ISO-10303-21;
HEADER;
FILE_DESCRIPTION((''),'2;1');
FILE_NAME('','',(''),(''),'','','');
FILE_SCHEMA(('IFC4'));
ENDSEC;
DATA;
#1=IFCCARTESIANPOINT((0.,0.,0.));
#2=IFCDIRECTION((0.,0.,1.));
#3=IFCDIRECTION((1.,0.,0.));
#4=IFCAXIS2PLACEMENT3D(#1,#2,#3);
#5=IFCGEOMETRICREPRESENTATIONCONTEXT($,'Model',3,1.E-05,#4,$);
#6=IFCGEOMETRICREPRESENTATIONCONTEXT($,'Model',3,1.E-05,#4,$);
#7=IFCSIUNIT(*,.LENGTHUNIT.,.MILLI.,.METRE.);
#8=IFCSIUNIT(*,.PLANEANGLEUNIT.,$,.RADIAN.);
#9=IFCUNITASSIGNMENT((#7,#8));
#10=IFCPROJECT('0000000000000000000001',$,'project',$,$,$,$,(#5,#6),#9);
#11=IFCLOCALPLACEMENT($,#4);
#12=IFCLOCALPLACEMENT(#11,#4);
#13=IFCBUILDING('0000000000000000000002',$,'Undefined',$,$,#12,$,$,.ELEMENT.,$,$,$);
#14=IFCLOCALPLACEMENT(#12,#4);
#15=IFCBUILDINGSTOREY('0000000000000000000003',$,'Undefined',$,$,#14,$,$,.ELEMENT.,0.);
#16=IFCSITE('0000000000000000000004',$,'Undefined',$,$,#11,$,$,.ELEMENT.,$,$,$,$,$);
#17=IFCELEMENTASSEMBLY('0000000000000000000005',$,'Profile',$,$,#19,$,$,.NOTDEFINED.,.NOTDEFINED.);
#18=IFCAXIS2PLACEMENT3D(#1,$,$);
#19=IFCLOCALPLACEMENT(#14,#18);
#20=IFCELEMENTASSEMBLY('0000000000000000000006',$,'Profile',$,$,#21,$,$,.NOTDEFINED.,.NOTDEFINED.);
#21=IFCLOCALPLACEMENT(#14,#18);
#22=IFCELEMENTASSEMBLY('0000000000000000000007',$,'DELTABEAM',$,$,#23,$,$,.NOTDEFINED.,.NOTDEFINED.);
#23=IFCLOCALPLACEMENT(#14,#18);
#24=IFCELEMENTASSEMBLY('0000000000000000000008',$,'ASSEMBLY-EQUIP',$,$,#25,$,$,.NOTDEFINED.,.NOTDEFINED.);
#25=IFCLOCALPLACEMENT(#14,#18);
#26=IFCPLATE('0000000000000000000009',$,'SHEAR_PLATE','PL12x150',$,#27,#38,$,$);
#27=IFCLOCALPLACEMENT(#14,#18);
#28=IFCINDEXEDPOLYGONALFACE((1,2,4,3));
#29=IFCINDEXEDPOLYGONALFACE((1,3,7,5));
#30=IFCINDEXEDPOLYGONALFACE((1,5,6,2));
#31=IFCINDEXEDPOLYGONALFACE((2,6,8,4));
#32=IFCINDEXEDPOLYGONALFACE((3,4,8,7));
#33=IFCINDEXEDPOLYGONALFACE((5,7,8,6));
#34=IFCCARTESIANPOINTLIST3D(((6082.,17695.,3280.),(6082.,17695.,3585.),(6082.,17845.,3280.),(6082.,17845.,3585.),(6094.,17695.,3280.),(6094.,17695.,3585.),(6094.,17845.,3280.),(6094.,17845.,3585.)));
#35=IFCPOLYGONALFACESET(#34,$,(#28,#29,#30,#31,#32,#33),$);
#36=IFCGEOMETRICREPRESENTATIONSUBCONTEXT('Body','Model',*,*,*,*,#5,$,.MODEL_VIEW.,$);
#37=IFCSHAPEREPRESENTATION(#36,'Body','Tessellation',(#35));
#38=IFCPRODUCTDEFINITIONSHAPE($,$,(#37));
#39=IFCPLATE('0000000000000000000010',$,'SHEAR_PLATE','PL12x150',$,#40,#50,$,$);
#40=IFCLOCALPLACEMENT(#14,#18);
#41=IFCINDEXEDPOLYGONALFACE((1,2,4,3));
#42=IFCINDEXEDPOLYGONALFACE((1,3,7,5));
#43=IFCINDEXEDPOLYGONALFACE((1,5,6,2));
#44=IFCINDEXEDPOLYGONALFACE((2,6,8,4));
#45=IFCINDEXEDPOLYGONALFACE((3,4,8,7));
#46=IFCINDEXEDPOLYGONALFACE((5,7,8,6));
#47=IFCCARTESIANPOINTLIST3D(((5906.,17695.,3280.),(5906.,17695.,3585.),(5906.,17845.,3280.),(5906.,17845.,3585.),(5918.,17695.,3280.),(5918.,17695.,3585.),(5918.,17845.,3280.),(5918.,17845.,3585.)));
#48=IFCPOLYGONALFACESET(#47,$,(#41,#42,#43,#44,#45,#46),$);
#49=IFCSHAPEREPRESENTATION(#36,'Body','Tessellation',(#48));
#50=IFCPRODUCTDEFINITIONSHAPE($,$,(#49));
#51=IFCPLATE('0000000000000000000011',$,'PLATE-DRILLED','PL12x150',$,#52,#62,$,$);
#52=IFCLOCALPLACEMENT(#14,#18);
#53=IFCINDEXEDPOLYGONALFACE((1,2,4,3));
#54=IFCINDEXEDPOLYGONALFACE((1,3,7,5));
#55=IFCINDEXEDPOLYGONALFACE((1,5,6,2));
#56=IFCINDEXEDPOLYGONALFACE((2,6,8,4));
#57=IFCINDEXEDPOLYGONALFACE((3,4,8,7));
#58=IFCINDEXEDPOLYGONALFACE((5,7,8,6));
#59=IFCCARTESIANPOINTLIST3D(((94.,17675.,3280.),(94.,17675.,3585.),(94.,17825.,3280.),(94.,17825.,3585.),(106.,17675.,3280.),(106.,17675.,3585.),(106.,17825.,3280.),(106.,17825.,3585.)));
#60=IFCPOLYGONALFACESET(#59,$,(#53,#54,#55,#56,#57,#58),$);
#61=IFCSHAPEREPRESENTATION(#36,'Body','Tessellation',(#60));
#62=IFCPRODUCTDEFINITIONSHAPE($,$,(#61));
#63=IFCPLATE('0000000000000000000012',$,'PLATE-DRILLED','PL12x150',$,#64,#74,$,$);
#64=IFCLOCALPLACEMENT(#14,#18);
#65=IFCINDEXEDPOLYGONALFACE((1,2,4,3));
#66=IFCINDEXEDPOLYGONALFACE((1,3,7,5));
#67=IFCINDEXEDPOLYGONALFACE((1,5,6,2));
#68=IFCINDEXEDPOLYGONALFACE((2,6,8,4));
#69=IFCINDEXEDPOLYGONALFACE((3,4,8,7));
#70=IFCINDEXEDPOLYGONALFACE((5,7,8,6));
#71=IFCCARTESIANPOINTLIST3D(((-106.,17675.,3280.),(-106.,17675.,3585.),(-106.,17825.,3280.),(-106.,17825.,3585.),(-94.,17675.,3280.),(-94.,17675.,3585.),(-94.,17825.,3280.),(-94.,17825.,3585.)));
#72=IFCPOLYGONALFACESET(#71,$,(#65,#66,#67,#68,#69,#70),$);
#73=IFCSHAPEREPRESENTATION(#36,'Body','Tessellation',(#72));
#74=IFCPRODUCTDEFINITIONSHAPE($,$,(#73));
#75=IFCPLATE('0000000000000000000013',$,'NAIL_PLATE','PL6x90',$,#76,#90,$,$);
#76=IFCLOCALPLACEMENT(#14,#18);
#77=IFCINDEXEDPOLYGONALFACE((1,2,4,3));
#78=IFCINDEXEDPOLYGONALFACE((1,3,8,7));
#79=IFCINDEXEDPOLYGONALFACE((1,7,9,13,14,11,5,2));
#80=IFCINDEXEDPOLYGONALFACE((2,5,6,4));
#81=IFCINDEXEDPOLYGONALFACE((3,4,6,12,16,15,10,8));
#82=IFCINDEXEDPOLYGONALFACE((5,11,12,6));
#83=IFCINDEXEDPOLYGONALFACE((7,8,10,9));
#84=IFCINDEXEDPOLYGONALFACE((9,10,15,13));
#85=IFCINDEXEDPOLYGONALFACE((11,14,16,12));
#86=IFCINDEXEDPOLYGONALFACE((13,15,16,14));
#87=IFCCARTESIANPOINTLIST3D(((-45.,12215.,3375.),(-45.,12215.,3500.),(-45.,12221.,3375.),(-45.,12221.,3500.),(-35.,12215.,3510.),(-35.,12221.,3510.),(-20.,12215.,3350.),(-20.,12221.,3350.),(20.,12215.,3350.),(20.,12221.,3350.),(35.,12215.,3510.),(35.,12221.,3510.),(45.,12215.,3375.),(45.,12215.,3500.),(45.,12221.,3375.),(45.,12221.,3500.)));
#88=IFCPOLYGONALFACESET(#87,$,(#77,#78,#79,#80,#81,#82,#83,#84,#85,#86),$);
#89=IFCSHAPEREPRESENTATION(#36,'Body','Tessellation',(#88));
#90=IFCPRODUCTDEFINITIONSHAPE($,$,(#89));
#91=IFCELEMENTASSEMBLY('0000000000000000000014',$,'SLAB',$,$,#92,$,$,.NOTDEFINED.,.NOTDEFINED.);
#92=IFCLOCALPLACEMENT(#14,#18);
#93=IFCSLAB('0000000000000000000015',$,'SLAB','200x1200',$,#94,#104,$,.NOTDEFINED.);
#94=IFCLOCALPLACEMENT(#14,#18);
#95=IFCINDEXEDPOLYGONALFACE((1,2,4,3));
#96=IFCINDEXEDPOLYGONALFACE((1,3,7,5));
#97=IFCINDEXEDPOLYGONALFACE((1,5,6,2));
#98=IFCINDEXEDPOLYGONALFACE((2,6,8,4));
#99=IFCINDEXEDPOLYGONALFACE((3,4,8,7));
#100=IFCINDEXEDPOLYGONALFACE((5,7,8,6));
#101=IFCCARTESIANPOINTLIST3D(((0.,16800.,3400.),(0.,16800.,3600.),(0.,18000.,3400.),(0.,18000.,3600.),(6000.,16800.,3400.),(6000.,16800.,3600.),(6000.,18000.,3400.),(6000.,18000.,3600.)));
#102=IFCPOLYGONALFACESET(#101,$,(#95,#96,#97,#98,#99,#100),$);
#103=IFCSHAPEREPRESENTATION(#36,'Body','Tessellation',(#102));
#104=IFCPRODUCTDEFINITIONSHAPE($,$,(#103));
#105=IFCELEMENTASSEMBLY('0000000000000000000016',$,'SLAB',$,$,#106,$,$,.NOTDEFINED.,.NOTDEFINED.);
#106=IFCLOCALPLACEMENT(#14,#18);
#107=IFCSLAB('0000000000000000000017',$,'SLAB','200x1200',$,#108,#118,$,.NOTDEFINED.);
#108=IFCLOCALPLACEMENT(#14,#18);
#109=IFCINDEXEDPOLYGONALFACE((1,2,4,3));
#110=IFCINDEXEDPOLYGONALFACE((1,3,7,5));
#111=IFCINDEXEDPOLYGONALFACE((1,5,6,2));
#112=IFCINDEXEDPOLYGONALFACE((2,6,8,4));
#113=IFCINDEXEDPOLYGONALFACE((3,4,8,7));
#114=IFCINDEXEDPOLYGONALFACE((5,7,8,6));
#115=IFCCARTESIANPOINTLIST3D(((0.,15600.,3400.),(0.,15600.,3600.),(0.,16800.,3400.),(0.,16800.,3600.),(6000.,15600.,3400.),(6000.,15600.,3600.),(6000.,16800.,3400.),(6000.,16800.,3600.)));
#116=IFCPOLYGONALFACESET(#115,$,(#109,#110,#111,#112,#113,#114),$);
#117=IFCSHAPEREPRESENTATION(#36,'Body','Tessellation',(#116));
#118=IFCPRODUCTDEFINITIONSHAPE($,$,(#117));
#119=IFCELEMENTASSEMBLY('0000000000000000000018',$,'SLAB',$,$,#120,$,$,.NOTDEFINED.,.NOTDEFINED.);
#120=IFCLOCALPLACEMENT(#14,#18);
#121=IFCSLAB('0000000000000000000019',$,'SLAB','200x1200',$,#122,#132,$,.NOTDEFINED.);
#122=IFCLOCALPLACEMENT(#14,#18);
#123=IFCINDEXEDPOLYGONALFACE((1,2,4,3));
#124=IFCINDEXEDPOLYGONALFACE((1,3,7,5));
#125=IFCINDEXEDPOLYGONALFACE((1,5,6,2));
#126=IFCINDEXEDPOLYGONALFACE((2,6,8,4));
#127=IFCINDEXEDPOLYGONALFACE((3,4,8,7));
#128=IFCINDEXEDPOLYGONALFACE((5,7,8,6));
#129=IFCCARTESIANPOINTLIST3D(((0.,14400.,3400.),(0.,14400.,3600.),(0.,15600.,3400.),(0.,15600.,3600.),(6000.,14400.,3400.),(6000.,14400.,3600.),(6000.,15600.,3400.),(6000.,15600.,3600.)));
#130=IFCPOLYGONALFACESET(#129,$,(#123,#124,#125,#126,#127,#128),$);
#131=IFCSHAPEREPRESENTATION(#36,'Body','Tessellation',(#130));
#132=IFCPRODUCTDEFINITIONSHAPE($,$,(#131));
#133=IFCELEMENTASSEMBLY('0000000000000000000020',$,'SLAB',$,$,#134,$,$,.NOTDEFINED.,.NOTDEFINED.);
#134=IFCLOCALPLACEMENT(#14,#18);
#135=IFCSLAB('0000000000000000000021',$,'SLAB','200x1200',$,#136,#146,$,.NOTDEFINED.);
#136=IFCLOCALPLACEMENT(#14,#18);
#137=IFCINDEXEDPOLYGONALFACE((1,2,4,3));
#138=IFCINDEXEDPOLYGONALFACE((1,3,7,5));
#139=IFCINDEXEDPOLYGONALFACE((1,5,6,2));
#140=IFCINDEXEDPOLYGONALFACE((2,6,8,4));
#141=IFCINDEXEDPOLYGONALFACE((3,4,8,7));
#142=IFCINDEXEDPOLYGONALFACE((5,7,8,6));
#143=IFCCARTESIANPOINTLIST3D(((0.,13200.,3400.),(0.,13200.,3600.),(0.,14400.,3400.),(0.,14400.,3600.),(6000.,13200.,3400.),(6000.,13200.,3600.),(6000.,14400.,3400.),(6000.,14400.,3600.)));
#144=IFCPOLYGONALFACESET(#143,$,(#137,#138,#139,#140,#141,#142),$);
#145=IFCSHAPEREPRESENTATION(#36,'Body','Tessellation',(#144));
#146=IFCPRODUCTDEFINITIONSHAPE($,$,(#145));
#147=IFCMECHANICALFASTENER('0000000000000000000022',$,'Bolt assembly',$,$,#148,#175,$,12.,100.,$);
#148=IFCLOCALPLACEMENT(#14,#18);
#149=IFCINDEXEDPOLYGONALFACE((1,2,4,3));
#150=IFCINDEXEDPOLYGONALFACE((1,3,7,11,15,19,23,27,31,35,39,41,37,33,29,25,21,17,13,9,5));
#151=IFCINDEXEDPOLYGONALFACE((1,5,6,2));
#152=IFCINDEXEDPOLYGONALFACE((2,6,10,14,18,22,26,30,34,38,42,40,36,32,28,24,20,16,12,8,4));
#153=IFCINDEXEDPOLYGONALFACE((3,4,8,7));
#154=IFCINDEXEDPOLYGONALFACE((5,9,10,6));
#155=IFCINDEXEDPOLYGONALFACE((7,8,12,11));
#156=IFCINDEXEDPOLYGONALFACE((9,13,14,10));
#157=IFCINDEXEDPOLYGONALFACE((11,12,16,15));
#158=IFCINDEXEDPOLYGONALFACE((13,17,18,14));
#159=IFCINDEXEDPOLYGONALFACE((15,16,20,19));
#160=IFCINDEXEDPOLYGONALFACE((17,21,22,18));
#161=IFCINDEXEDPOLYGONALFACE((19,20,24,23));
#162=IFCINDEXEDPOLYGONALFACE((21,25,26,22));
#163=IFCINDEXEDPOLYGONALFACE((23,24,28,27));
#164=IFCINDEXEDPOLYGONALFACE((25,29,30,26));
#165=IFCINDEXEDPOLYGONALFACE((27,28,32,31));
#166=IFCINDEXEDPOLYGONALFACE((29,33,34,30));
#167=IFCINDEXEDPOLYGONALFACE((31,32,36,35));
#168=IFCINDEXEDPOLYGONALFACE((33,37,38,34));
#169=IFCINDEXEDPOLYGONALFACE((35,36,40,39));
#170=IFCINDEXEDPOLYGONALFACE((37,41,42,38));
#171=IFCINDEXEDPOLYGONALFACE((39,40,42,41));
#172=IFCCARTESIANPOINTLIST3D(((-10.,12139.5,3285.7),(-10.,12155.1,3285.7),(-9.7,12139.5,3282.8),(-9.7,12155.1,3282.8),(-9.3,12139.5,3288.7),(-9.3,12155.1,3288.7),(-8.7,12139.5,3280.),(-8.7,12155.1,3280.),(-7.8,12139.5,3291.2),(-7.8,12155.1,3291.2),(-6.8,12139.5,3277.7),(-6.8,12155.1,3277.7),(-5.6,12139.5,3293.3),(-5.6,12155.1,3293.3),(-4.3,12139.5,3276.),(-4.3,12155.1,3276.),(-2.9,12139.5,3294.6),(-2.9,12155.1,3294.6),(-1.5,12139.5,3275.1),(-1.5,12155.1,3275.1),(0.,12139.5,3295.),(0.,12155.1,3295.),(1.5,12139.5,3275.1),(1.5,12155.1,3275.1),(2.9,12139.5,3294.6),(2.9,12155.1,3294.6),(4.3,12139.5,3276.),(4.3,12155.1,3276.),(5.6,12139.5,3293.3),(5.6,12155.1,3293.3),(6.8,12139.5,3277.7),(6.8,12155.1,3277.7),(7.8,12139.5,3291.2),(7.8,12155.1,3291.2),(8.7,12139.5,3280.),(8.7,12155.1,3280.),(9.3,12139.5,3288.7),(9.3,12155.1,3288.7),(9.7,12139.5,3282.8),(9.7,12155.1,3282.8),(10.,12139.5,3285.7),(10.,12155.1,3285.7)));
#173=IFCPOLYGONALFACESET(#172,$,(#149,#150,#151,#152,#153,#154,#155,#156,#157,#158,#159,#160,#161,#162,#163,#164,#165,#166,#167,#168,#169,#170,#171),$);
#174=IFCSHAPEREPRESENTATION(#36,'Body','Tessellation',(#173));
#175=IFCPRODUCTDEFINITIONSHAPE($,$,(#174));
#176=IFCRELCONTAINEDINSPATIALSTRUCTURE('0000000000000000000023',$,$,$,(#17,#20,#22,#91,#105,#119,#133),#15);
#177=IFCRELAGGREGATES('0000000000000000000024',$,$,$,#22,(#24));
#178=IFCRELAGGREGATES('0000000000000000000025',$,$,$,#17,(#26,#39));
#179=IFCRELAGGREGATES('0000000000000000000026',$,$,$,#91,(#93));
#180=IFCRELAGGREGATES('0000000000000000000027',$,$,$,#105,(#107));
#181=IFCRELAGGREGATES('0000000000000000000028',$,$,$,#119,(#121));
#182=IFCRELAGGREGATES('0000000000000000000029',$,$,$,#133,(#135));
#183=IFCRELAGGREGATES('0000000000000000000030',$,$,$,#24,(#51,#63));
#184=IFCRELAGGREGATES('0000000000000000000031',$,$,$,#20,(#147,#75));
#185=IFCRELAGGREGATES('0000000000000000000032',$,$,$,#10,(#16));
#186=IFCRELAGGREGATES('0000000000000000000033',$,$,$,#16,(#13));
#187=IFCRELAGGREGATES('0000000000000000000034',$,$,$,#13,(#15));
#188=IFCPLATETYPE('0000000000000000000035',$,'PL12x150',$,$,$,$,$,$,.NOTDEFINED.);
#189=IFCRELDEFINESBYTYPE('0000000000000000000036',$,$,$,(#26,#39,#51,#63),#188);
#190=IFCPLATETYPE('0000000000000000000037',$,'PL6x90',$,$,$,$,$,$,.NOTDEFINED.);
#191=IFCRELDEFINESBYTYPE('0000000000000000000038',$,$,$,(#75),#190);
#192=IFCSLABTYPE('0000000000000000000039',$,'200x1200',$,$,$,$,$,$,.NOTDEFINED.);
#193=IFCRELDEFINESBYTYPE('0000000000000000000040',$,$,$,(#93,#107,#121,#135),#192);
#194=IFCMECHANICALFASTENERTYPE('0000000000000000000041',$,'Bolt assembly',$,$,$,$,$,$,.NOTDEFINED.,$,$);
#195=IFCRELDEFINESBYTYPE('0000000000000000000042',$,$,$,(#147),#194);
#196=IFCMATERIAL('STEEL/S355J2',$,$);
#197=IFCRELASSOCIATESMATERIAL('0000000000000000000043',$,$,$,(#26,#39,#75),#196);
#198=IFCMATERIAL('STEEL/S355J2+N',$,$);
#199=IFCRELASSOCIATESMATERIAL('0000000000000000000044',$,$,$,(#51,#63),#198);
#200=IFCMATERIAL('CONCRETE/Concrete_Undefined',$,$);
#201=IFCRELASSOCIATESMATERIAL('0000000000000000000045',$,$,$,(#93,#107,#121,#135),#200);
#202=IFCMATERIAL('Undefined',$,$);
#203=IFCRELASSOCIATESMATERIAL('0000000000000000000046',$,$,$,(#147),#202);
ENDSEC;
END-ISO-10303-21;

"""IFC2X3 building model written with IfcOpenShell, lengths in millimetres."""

from ifc_helpers import new_model, si_unit, frame, origin_with_axes, origin_2d_with_axis, place, context, subcontext, project, spatial, polyline, circle, outline, extrude, source, transform, mapped, material, type_object, element, aggregate, save


model = new_model("IFC2X3")

# Units and contexts
model_context_1 = context("Model", 3, precision=1e-05, world=origin_with_axes())
model_context_2 = context("Model", 3, precision=1e-05, world=origin_with_axes())
body_context = subcontext(model_context_1, "Body", "Model", "MODEL_VIEW")
ifc_project = project(units=[si_unit("LENGTHUNIT", "METRE", prefix="MILLI"), si_unit("PLANEANGLEUNIT", "RADIAN")], contexts=[model_context_1, model_context_2])

# Site, building, storey
site_placement = place(None, origin_with_axes())
site = spatial("IfcSite", under=ifc_project, at=site_placement, Name="Undefined", CompositionType="ELEMENT")
building_placement = place(site_placement, origin_with_axes())
building = spatial("IfcBuilding", under=site, at=building_placement, Name="Undefined", CompositionType="ELEMENT")
storey_placement = place(building_placement, origin_with_axes())
storey = spatial("IfcBuildingStorey", under=building, at=storey_placement, Name="Undefined", CompositionType="ELEMENT", Elevation=0.0)

# Shared definitions
ifc_material_1 = material(Name="CONCRETE/Concrete_Undefined")

# Element assembly
assembly_1_placement = place(storey_placement, origin_with_axes())
assembly_1 = element("IfcElementAssembly", 1, at=assembly_1_placement, inside=storey, Name="Profile", AssemblyPlace="NOTDEFINED", PredefinedType="NOTDEFINED")

# Shared definitions
ifc_material_2 = material(Name="STEEL/S355J2")

# Element assembly
assembly_2_placement = place(storey_placement, origin_with_axes())
assembly_2 = element("IfcElementAssembly", 2, at=assembly_2_placement, inside=storey, Name="Profile", AssemblyPlace="NOTDEFINED", PredefinedType="NOTDEFINED")

# Element assemblies
ifc_material_3 = material(Name="STEEL/S355J2+N")
assembly_3_placement = place(storey_placement, origin_with_axes())
assembly_3 = element("IfcElementAssembly", 3, at=assembly_3_placement, inside=storey, Name="DELTABEAM", AssemblyPlace="NOTDEFINED", PredefinedType="NOTDEFINED")
assembly_4_placement = place(assembly_3_placement, origin_with_axes())
assembly_4 = element("IfcElementAssembly", 4, at=assembly_4_placement, Name="ASSEMBLY-EQUIP", AssemblyPlace="NOTDEFINED", PredefinedType="NOTDEFINED")
aggregate(assembly_3, [assembly_4])

# Plates
plate_type_1 = type_object("IfcPlateType", Name="PL12x150", PredefinedType="NOTDEFINED")
plate_1_placement = place(assembly_1_placement, frame((6088.0, 17845.0, 3585.0), z_axis=(1.0, 0.0, 0.0), x_axis=(0.0, -1.0, 0.0)))
plate_1 = element("IfcPlate", 5, at=plate_1_placement, type_object=plate_type_1, material=ifc_material_2, Name="SHEAR_PLATE", Description="PL12x150", context=body_context, shape_type="SweptSolid", body=[
    extrude(outline(polyline([(0.0, 0.0), (150.0, 0.0), (150.0, 0.0), (150.0, 305.0), (150.0, 305.0), (0.0, 305.0), (0.0, 305.0), (0.0, 0.0)])), frame((0.0, 0.0, -6.0), z_axis=(0.0, 0.0, 1.0), x_axis=(1.0, 0.0, 0.0)), (0.0, 0.0, 1.0), 12.0),
])
plate_2_placement = place(assembly_1_placement, frame((5912.0, 17845.0, 3585.0), z_axis=(1.0, 0.0, 0.0), x_axis=(0.0, -1.0, 0.0)))
plate_2 = element("IfcPlate", 6, at=plate_2_placement, type_object=plate_type_1, material=ifc_material_2, Name="SHEAR_PLATE", Description="PL12x150", context=body_context, shape_type="SweptSolid", body=[
    extrude(outline(polyline([(0.0, 0.0), (150.0, 0.0), (150.0, 0.0), (150.0, 305.0), (150.0, 305.0), (0.0, 305.0), (0.0, 305.0), (0.0, 0.0)])), frame((0.0, 0.0, -6.0), z_axis=(0.0, 0.0, 1.0), x_axis=(1.0, 0.0, 0.0)), (0.0, 0.0, 1.0), 12.0),
])
aggregate(assembly_1, [plate_1, plate_2])
plate_3_placement = place(assembly_4_placement, frame((100.0, 17675.0, 3585.0), z_axis=(-1.0, 0.0, 0.0), x_axis=(0.0, 1.0, 0.0)))
plate_3 = element("IfcPlate", 7, at=plate_3_placement, type_object=plate_type_1, material=ifc_material_3, Name="PLATE-DRILLED", Description="PL12x150", context=body_context, shape_type="SweptSolid", body=[
    extrude(outline(polyline([(0.0, 0.0), (150.0, 0.0), (150.0, 0.0), (150.0, 305.0), (150.0, 305.0), (0.0, 305.0), (0.0, 305.0), (0.0, 0.0)])), frame((0.0, 0.0, -6.0), z_axis=(0.0, 0.0, 1.0), x_axis=(1.0, 0.0, 0.0)), (0.0, 0.0, 1.0), 12.0),
])
plate_4_placement = place(assembly_4_placement, frame((-100.0, 17675.0, 3585.0), z_axis=(-1.0, 0.0, 0.0), x_axis=(0.0, 1.0, 0.0)))
plate_4 = element("IfcPlate", 8, at=plate_4_placement, type_object=plate_type_1, material=ifc_material_3, Name="PLATE-DRILLED", Description="PL12x150", context=body_context, shape_type="SweptSolid", body=[
    extrude(outline(polyline([(0.0, 0.0), (150.0, 0.0), (150.0, 0.0), (150.0, 305.0), (150.0, 305.0), (0.0, 305.0), (0.0, 305.0), (0.0, 0.0)])), frame((0.0, 0.0, -6.0), z_axis=(0.0, 0.0, 1.0), x_axis=(1.0, 0.0, 0.0)), (0.0, 0.0, 1.0), 12.0),
])
plate_type_2 = type_object("IfcPlateType", Name="PL6x90", PredefinedType="NOTDEFINED")
plate_5_placement = place(assembly_2_placement, frame((45.0, 12218.0, 3510.0), z_axis=(0.0, -1.0, 0.0), x_axis=(-1.0, 0.0, 0.0)))
plate_5 = element("IfcPlate", 9, at=plate_5_placement, type_object=plate_type_2, material=ifc_material_2, Name="NAIL_PLATE", Description="PL6x90", context=body_context, shape_type="SweptSolid", body=[
    extrude(outline(polyline([(0.0, 10.0), (10.0, 0.0), (80.0, 0.0), (90.0, 10.0), (90.0, 135.0), (65.0, 160.0), (25.0, 160.0), (0.0, 135.0), (0.0, 10.0)])), frame((0.0, 0.0, -3.0), z_axis=(0.0, 0.0, 1.0), x_axis=(1.0, 0.0, 0.0)), (0.0, 0.0, 1.0), 6.0),
])

# Element assemblies, slabs
assembly_5_placement = place(storey_placement, origin_with_axes())
assembly_5 = element("IfcElementAssembly", 10, at=assembly_5_placement, inside=storey, Name="SLAB", AssemblyPlace="NOTDEFINED", PredefinedType="NOTDEFINED")
slab_type = type_object("IfcSlabType", Name="200x1200", PredefinedType="NOTDEFINED")
slab_1_placement = place(assembly_5_placement, frame((6000.0, 16800.0, 3500.0), z_axis=(0.0, 0.0, 1.0), x_axis=(0.0, 1.0, 0.0)))
slab_1 = element("IfcSlab", 11, at=slab_1_placement, type_object=slab_type, material=ifc_material_1, Name="SLAB", Description="200x1200", PredefinedType="NOTDEFINED", context=body_context, shape_type="SweptSolid", body=[
    extrude(outline(polyline([(0.0, 0.0), (1200.0, 0.0), (1200.0, 6000.0), (0.0, 6000.0), (0.0, 0.0)])), frame((0.0, 0.0, -100.0), z_axis=(0.0, 0.0, 1.0), x_axis=(1.0, 0.0, 0.0)), (0.0, 0.0, 1.0), 200.0),
])
aggregate(assembly_5, [slab_1])
assembly_6_placement = place(storey_placement, origin_with_axes())
assembly_6 = element("IfcElementAssembly", 12, at=assembly_6_placement, inside=storey, Name="SLAB", AssemblyPlace="NOTDEFINED", PredefinedType="NOTDEFINED")
slab_2_placement = place(assembly_6_placement, frame((6000.0, 15600.0, 3500.0), z_axis=(0.0, 0.0, 1.0), x_axis=(0.0, 1.0, 0.0)))
slab_2 = element("IfcSlab", 13, at=slab_2_placement, type_object=slab_type, material=ifc_material_1, Name="SLAB", Description="200x1200", PredefinedType="NOTDEFINED", context=body_context, shape_type="SweptSolid", body=[
    extrude(outline(polyline([(0.0, 0.0), (1200.0, 0.0), (1200.0, 6000.0), (0.0, 6000.0), (0.0, 0.0)])), frame((0.0, 0.0, -100.0), z_axis=(0.0, 0.0, 1.0), x_axis=(1.0, 0.0, 0.0)), (0.0, 0.0, 1.0), 200.0),
])
aggregate(assembly_6, [slab_2])
assembly_7_placement = place(storey_placement, origin_with_axes())
assembly_7 = element("IfcElementAssembly", 14, at=assembly_7_placement, inside=storey, Name="SLAB", AssemblyPlace="NOTDEFINED", PredefinedType="NOTDEFINED")
slab_3_placement = place(assembly_7_placement, frame((6000.0, 14400.0, 3500.0), z_axis=(0.0, 0.0, 1.0), x_axis=(0.0, 1.0, 0.0)))
slab_3 = element("IfcSlab", 15, at=slab_3_placement, type_object=slab_type, material=ifc_material_1, Name="SLAB", Description="200x1200", PredefinedType="NOTDEFINED", context=body_context, shape_type="SweptSolid", body=[
    extrude(outline(polyline([(0.0, 0.0), (1200.0, 0.0), (1200.0, 6000.0), (0.0, 6000.0), (0.0, 0.0)])), frame((0.0, 0.0, -100.0), z_axis=(0.0, 0.0, 1.0), x_axis=(1.0, 0.0, 0.0)), (0.0, 0.0, 1.0), 200.0),
])
aggregate(assembly_7, [slab_3])
assembly_8_placement = place(storey_placement, origin_with_axes())
assembly_8 = element("IfcElementAssembly", 16, at=assembly_8_placement, inside=storey, Name="SLAB", AssemblyPlace="NOTDEFINED", PredefinedType="NOTDEFINED")
slab_4_placement = place(assembly_8_placement, frame((6000.0, 13200.0, 3500.0), z_axis=(0.0, 0.0, 1.0), x_axis=(0.0, 1.0, 0.0)))
slab_4 = element("IfcSlab", 17, at=slab_4_placement, type_object=slab_type, material=ifc_material_1, Name="SLAB", Description="200x1200", PredefinedType="NOTDEFINED", context=body_context, shape_type="SweptSolid", body=[
    extrude(outline(polyline([(0.0, 0.0), (1200.0, 0.0), (1200.0, 6000.0), (0.0, 6000.0), (0.0, 0.0)])), frame((0.0, 0.0, -100.0), z_axis=(0.0, 0.0, 1.0), x_axis=(1.0, 0.0, 0.0)), (0.0, 0.0, 1.0), 200.0),
])
aggregate(assembly_8, [slab_4])

# Mechanical fastener
mechanical_fastener_type = type_object("IfcMechanicalFastenerType", Name="Bolt assembly")
aggregate(assembly_4, [plate_3, plate_4])
ifc_material_4 = material(Name="Undefined")
shared_shape_1 = source(origin_with_axes(), body_context, "Body", "SweptSolid", [
    extrude(circle(Radius=10.0, at=origin_2d_with_axis()), frame((0.0, -15.5, 0.0), z_axis=(0.0, 1.0, 0.0), x_axis=(1.0, 0.0, 0.0)), (0.0, 0.0, 1.0), 15.6),
])
mechanical_fastener_1_placement = place(assembly_2_placement, frame((0.0, 12155.0, 3285.0), z_axis=(-1.0, 0.0, 0.0), x_axis=(0.0, 0.0, 1.0)))
mechanical_fastener_1 = element("IfcMechanicalFastener", 18, at=mechanical_fastener_1_placement, type_object=mechanical_fastener_type, material=ifc_material_4, Name="Bolt assembly", NominalDiameter=12.0, NominalLength=100.0, context=body_context, shape_type="MappedRepresentation", body=[
    mapped(shared_shape_1, transform((0.0, 0.0, 0.0))),
])
aggregate(assembly_2, [mechanical_fastener_1, plate_5])

save(model, "model.ifc")
